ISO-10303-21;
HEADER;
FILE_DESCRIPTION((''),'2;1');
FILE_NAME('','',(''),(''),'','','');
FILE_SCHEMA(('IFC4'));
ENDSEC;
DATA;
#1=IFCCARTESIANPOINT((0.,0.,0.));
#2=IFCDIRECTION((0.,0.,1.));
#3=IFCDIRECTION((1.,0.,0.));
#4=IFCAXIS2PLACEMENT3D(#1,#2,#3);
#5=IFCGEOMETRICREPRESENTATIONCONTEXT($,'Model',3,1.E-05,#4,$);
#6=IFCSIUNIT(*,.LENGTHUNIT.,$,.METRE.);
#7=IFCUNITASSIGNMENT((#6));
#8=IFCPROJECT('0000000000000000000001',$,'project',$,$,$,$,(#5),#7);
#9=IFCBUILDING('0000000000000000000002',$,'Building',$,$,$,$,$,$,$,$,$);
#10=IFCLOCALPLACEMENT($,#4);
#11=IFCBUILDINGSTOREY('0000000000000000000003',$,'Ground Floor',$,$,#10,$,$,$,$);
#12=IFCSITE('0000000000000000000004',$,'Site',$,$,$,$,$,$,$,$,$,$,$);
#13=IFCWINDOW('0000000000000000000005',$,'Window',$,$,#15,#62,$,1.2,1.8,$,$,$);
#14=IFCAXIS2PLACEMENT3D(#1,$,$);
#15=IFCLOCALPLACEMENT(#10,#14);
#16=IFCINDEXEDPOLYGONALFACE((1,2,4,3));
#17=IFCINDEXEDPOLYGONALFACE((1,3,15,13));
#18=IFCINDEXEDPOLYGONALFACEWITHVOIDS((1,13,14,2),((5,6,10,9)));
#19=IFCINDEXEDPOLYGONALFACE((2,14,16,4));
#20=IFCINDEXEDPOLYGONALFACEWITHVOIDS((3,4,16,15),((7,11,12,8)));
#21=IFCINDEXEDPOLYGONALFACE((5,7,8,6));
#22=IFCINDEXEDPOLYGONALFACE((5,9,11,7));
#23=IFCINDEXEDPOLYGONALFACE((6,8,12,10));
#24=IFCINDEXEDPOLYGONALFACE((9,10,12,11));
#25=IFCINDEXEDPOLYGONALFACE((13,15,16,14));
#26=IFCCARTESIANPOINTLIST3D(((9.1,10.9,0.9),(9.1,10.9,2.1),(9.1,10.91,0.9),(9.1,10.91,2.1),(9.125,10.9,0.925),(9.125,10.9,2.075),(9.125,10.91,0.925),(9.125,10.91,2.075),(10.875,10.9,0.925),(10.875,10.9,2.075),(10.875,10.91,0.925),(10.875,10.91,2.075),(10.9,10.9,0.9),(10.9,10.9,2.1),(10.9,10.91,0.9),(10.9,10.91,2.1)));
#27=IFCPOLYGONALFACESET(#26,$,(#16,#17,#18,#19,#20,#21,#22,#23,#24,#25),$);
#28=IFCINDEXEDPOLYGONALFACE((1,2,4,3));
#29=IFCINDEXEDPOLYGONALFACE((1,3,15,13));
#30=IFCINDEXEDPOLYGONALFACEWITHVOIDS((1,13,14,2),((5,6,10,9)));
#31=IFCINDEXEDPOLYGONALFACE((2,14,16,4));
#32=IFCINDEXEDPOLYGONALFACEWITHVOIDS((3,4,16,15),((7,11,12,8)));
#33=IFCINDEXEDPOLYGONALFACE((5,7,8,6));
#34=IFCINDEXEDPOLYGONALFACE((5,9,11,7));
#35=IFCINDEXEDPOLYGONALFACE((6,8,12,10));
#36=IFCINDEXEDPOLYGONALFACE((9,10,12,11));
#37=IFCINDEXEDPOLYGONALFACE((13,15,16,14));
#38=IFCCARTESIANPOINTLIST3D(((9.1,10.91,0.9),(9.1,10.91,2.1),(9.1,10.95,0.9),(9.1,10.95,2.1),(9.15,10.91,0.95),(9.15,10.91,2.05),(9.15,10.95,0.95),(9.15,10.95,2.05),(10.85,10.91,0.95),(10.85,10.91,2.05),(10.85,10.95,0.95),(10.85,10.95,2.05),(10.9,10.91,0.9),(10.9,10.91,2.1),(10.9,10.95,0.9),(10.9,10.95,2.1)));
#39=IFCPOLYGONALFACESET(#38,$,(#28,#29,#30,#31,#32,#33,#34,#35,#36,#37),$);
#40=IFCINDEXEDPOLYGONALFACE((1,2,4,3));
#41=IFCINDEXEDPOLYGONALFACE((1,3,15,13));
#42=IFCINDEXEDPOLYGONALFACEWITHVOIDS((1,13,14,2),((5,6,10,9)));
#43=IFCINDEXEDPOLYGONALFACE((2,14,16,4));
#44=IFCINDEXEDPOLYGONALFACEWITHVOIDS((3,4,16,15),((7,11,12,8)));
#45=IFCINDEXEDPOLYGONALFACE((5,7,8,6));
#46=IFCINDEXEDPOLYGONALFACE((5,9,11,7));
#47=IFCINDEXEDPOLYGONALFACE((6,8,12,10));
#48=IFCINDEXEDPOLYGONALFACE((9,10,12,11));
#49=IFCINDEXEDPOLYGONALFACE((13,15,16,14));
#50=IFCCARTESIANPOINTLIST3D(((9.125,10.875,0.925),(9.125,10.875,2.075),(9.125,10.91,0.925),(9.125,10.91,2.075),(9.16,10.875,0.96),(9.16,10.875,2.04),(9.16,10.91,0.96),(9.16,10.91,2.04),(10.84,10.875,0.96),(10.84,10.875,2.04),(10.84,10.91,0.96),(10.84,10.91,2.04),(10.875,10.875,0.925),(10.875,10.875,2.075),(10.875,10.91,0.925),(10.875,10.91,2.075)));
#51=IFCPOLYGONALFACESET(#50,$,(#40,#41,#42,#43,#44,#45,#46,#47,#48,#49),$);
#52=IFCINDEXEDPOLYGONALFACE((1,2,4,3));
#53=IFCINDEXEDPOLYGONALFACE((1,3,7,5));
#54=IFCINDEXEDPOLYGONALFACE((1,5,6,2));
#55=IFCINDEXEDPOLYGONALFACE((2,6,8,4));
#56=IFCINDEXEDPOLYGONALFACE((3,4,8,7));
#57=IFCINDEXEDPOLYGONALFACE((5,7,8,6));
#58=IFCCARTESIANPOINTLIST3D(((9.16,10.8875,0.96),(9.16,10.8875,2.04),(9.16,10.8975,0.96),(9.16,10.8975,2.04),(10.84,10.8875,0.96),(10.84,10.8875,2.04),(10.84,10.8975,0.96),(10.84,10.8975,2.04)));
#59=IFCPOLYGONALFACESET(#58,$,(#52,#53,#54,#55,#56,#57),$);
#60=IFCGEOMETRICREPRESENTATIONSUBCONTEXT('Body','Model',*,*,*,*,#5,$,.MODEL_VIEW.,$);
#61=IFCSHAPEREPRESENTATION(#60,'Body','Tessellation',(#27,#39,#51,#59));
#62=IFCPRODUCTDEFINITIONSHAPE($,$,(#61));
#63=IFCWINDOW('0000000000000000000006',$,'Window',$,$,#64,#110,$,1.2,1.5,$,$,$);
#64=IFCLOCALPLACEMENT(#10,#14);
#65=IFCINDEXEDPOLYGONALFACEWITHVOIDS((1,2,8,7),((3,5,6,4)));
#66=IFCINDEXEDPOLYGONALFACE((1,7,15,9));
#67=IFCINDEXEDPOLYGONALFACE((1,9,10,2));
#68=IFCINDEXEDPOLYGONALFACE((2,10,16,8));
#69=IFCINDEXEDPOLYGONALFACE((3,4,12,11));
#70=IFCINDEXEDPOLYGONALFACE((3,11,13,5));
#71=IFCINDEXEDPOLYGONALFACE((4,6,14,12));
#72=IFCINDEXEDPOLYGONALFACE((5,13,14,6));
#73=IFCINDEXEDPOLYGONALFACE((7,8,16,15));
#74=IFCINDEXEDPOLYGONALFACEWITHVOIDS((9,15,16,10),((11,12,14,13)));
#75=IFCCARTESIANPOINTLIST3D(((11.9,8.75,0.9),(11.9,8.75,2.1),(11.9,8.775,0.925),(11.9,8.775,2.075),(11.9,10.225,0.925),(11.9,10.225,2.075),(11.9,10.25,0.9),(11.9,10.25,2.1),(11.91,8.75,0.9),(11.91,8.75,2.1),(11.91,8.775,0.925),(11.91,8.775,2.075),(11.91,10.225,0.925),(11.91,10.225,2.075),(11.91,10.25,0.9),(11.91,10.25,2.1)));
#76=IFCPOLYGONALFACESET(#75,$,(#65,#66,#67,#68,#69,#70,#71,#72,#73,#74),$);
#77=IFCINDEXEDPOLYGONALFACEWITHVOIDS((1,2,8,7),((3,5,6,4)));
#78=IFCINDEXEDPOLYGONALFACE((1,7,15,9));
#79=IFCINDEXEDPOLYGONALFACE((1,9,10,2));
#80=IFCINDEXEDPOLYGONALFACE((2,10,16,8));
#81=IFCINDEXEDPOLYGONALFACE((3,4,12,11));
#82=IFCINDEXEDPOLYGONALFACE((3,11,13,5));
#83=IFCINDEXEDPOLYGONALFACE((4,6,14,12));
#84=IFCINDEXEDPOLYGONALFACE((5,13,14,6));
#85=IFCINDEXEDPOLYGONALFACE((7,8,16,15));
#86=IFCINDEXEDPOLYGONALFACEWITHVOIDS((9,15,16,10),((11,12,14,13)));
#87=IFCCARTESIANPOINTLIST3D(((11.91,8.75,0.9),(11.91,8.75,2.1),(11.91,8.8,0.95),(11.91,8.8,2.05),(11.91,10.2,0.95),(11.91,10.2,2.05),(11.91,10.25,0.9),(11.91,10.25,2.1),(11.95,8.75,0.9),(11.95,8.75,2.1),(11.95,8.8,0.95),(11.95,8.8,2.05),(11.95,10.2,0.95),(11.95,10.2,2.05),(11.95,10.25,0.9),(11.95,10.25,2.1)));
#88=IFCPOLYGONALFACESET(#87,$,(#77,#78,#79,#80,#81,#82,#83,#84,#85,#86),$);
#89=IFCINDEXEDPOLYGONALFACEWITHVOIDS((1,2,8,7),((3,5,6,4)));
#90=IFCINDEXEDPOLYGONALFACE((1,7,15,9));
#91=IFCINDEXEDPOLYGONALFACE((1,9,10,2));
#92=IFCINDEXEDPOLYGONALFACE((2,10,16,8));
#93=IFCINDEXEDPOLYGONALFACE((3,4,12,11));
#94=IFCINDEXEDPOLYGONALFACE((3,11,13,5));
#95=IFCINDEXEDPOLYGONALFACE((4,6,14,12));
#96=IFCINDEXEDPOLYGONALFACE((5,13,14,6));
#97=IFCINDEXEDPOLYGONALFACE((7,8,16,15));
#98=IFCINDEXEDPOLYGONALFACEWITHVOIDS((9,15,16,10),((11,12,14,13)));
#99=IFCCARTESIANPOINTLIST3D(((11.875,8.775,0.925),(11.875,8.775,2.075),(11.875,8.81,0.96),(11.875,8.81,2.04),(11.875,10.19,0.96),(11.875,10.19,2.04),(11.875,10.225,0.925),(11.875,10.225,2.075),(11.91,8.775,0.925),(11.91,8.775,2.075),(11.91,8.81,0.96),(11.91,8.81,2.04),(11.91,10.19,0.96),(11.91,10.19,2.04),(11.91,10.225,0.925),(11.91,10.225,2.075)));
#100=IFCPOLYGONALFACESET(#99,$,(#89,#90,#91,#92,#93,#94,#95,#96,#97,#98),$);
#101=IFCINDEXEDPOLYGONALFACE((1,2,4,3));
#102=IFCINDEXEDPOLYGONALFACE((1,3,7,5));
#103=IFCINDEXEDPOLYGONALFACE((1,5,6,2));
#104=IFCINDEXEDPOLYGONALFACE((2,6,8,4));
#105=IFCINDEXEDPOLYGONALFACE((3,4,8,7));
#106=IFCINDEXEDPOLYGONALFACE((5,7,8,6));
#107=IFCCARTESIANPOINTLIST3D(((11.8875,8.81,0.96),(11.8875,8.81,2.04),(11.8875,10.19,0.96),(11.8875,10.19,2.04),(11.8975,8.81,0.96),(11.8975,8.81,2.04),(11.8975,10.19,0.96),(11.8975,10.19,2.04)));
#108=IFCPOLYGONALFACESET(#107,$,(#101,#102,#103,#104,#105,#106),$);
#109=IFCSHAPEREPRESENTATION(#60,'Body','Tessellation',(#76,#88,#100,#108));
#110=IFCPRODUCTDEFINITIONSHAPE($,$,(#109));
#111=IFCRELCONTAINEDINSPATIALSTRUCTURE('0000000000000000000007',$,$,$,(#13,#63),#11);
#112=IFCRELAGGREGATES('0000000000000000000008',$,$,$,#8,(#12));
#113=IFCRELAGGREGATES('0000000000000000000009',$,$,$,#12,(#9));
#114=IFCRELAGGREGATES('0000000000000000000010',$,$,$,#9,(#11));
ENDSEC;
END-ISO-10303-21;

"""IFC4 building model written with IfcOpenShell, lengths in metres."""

from ifc_helpers import new_model, si_unit, frame, origin_with_axes, place, context, subcontext, project, spatial, line, indexed_curve, outline, extrude, element, save


model = new_model("IFC4")

# Units and contexts
model_context = context("Model", 3, precision=1e-05, world=origin_with_axes())
body_context = subcontext(model_context, "Body", "Model", "MODEL_VIEW")
ifc_project = project(units=[si_unit("LENGTHUNIT", "METRE")], contexts=[model_context])

# Site, building, storey
site = spatial("IfcSite", under=ifc_project, Name="Site")
building = spatial("IfcBuilding", under=site, Name="Building")
storey_placement = place(None, origin_with_axes())
storey = spatial("IfcBuildingStorey", under=building, at=storey_placement, Name="Ground Floor")

# Windows
window_1_placement = place(storey_placement, frame((10.9, 11.0, 0.9), z_axis=(0.0, 0.0, 1.0), x_axis=(-1.0, 0.0, 0.0)))
element("IfcWindow", 1, at=window_1_placement, inside=storey, Name="Window", OverallHeight=1.2, OverallWidth=1.8, context=body_context, shape_type="SweptSolid", body=[
    extrude(outline(indexed_curve([(0.0, 0.0), (1.8, 0.0), (1.8, 1.2), (0.0, 1.2)], segments=[line(1, 2, 3, 4, 1)]), holes=[indexed_curve([(0.025, 0.025), (1.775, 0.025), (1.775, 1.175), (0.025, 1.175)], segments=[line(1, 2, 3, 4, 1)])]), frame((0.0, 0.09, 0.0), z_axis=(0.0, -1.0, 0.0), x_axis=(1.0, 0.0, 0.0)), (0.0, 0.0, -1.0), 0.01),
    extrude(outline(indexed_curve([(0.0, 0.0), (1.8, 0.0), (1.8, 1.2), (0.0, 1.2)], segments=[line(1, 2, 3, 4, 1)]), holes=[indexed_curve([(0.05, 0.05), (1.75, 0.05), (1.75, 1.15), (0.05, 1.15)], segments=[line(1, 2, 3, 4, 1)])]), frame((0.0, 0.05, 0.0), z_axis=(0.0, -1.0, 0.0), x_axis=(1.0, 0.0, 0.0)), (0.0, 0.0, -1.0), 0.04),
    extrude(outline(indexed_curve([(0.0, 0.0), (1.75, 0.0), (1.75, 1.15), (0.0, 1.15)], segments=[line(1, 2, 3, 4, 1)]), holes=[indexed_curve([(0.035, 0.035), (1.715, 0.035), (1.715, 1.115), (0.035, 1.115)], segments=[line(1, 2, 3, 4, 1)])]), frame((0.025, 0.09, 0.025), z_axis=(0.0, -1.0, 0.0), x_axis=(1.0, 0.0, 0.0)), (0.0, 0.0, -1.0), 0.035),
    extrude(outline(indexed_curve([(0.035, 0.035), (1.715, 0.035), (1.715, 1.115), (0.035, 1.115)], segments=[line(1, 2, 3, 4, 1)])), frame((0.025, 0.1025, 0.025), z_axis=(0.0, -1.0, 0.0), x_axis=(1.0, 0.0, 0.0)), (0.0, 0.0, -1.0), 0.01),
])
window_2_placement = place(storey_placement, frame((12.0, 8.75, 0.9), z_axis=(0.0, 0.0, 1.0), x_axis=(0.0, 1.0, 0.0)))
element("IfcWindow", 2, at=window_2_placement, inside=storey, Name="Window", OverallHeight=1.2, OverallWidth=1.5, context=body_context, shape_type="SweptSolid", body=[
    extrude(outline(indexed_curve([(0.0, 0.0), (1.5, 0.0), (1.5, 1.2), (0.0, 1.2)], segments=[line(1, 2, 3, 4, 1)]), holes=[indexed_curve([(0.025, 0.025), (1.475, 0.025), (1.475, 1.175), (0.025, 1.175)], segments=[line(1, 2, 3, 4, 1)])]), frame((0.0, 0.09, 0.0), z_axis=(0.0, -1.0, 0.0), x_axis=(1.0, 0.0, 0.0)), (0.0, 0.0, -1.0), 0.01),
    extrude(outline(indexed_curve([(0.0, 0.0), (1.5, 0.0), (1.5, 1.2), (0.0, 1.2)], segments=[line(1, 2, 3, 4, 1)]), holes=[indexed_curve([(0.05, 0.05), (1.45, 0.05), (1.45, 1.15), (0.05, 1.15)], segments=[line(1, 2, 3, 4, 1)])]), frame((0.0, 0.05, 0.0), z_axis=(0.0, -1.0, 0.0), x_axis=(1.0, 0.0, 0.0)), (0.0, 0.0, -1.0), 0.04),
    extrude(outline(indexed_curve([(0.0, 0.0), (1.45, 0.0), (1.45, 1.15), (0.0, 1.15)], segments=[line(1, 2, 3, 4, 1)]), holes=[indexed_curve([(0.035, 0.035), (1.415, 0.035), (1.415, 1.115), (0.035, 1.115)], segments=[line(1, 2, 3, 4, 1)])]), frame((0.025, 0.09, 0.025), z_axis=(0.0, -1.0, 0.0), x_axis=(1.0, 0.0, 0.0)), (0.0, 0.0, -1.0), 0.035),
    extrude(outline(indexed_curve([(0.035, 0.035), (1.415, 0.035), (1.415, 1.115), (0.035, 1.115)], segments=[line(1, 2, 3, 4, 1)])), frame((0.025, 0.1025, 0.025), z_axis=(0.0, -1.0, 0.0), x_axis=(1.0, 0.0, 0.0)), (0.0, 0.0, -1.0), 0.01),
])

save(model, "model.ifc")
